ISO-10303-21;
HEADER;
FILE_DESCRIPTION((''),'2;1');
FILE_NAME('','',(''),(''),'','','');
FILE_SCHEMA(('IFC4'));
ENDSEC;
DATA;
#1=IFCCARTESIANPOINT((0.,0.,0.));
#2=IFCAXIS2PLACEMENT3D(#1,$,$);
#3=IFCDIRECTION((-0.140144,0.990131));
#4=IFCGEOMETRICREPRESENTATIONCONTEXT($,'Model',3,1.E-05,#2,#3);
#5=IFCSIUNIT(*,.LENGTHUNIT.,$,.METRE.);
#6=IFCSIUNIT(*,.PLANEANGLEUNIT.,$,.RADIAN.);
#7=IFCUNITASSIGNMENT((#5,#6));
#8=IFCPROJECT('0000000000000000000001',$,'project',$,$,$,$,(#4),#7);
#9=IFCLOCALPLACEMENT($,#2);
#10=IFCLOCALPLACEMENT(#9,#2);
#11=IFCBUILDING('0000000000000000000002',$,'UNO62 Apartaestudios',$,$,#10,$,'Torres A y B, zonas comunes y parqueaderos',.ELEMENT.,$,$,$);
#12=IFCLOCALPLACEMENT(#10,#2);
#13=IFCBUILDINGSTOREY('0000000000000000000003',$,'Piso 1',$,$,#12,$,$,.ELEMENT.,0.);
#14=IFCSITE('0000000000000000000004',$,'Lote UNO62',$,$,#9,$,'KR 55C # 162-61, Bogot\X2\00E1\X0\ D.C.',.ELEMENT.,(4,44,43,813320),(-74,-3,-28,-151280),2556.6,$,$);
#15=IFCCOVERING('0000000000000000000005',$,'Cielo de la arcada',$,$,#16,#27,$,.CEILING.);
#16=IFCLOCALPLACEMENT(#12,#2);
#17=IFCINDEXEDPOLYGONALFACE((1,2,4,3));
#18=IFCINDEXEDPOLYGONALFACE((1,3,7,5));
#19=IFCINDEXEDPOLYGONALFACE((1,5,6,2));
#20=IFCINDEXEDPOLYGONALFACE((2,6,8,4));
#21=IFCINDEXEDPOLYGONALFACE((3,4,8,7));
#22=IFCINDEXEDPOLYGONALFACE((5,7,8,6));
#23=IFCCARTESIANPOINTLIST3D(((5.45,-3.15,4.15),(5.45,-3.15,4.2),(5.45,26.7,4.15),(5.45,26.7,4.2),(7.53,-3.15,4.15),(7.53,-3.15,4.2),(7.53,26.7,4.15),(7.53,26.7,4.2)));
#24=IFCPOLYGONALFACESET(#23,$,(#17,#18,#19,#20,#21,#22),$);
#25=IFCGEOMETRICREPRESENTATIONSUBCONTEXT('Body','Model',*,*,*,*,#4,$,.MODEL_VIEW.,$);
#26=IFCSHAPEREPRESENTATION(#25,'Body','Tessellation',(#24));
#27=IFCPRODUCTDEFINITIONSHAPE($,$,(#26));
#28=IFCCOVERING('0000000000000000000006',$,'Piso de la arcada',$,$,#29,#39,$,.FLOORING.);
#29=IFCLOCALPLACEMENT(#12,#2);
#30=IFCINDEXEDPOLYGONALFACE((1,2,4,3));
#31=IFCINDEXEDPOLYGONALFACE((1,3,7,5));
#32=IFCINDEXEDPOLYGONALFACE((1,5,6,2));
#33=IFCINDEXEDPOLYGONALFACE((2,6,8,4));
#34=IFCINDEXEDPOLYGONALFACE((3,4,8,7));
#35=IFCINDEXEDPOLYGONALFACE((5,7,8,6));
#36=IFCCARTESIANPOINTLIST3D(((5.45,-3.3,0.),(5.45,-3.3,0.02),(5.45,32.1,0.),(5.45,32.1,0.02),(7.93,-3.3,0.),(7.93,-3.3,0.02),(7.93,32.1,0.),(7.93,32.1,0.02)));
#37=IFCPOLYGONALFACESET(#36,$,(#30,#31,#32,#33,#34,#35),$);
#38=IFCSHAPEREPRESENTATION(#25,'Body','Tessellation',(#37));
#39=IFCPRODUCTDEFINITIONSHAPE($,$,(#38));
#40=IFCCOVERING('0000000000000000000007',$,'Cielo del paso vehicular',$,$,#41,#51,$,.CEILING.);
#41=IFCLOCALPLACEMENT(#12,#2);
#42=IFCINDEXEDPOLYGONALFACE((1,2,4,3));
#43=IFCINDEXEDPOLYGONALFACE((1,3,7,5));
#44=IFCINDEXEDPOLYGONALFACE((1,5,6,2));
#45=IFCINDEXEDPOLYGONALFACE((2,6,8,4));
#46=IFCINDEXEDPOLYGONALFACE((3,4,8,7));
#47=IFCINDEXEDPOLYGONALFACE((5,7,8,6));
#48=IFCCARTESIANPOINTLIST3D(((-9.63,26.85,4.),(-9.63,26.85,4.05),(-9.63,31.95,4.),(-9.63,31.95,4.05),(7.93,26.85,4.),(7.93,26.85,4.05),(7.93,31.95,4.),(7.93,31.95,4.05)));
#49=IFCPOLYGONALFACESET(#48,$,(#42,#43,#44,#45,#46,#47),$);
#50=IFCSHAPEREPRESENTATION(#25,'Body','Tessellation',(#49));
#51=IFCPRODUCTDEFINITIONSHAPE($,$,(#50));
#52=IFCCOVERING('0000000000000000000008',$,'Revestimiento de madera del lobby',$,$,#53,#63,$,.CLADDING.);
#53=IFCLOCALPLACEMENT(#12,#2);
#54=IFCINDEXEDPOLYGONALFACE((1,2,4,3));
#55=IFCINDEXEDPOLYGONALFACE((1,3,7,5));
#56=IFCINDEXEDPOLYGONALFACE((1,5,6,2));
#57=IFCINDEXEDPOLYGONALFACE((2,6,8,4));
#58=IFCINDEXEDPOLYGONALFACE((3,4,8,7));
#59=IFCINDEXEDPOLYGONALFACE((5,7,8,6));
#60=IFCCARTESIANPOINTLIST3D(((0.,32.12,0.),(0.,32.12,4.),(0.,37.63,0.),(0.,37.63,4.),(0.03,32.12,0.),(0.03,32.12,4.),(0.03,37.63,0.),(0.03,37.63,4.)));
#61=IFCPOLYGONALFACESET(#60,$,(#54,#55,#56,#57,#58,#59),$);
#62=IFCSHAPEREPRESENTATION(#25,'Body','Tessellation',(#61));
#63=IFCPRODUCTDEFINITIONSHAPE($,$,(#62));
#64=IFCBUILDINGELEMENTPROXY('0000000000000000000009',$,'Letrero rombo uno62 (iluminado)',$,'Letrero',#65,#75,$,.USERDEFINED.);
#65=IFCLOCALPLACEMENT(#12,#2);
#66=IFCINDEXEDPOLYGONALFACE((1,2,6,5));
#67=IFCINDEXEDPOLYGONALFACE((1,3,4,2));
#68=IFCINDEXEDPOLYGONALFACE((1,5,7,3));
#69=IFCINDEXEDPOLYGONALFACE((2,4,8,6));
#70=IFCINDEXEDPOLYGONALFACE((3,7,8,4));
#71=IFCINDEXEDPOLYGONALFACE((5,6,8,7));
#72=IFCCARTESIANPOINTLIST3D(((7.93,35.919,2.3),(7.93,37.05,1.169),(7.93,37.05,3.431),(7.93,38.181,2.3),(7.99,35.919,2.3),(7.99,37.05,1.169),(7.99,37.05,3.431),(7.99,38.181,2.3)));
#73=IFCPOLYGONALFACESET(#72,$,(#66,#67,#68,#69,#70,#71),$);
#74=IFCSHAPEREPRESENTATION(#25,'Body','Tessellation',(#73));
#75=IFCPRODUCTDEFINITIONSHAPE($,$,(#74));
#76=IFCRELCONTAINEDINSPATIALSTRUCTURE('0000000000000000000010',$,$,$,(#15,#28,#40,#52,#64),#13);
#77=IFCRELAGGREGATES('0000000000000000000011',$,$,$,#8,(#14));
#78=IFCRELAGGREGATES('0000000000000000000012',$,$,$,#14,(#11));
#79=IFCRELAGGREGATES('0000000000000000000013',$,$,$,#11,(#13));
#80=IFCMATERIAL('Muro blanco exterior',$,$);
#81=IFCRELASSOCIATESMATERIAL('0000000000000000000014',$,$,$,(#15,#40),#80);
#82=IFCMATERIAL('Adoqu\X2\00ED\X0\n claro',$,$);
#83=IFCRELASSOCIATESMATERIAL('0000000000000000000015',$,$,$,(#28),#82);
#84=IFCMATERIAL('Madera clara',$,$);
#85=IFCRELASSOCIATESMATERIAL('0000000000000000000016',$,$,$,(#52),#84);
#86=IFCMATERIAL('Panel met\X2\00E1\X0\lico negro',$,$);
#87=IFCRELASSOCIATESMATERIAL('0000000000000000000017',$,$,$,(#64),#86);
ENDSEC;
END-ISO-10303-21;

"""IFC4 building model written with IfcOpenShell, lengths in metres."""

from ifc_helpers import new_model, si_unit, direction, frame, frame_2d, origin, place, context, subcontext, project, spatial, polyline, rectangle, outline, extrude, material, element, save


model = new_model("IFC4")

# Units and contexts
model_context = context("Model", 3, precision=1e-05, world=origin(), true_north=direction((-0.140144, 0.990131)))
body_context = subcontext(model_context, "Body", "Model", "MODEL_VIEW")
ifc_project = project(units=[si_unit("LENGTHUNIT", "METRE"), si_unit("PLANEANGLEUNIT", "RADIAN")], contexts=[model_context])

# Site, building, storey
site_placement = place(None, origin())
site = spatial("IfcSite", under=ifc_project, at=site_placement, Name="Lote UNO62", LongName="KR 55C # 162-61, Bogotá D.C.", CompositionType="ELEMENT", RefLatitude=(4, 44, 43, 813320), RefLongitude=(-74, -3, -28, -151280), RefElevation=2556.6)
building_placement = place(site_placement, origin())
building = spatial("IfcBuilding", under=site, at=building_placement, Name="UNO62 Apartaestudios", LongName="Torres A y B, zonas comunes y parqueaderos", CompositionType="ELEMENT")
storey_placement = place(building_placement, origin())
storey = spatial("IfcBuildingStorey", under=building, at=storey_placement, Name="Piso 1", CompositionType="ELEMENT", Elevation=0.0)

# Shared definitions
ifc_material_1 = material(Name="Panel metálico negro")

# Shared definitions
ifc_material_2 = material(Name="Muro blanco exterior")

# Coverings
covering_1_placement = place(storey_placement, origin())
element("IfcCovering", 1, at=covering_1_placement, inside=storey, material=ifc_material_2, Name="Cielo de la arcada", PredefinedType="CEILING", context=body_context, shape_type="SweptSolid", body=[
    extrude(rectangle(XDim=2.08, YDim=29.85, at=frame_2d((6.49, 11.775))), frame((0.0, 0.0, 4.15)), (0.0, 0.0, 1.0), 0.05),
])
ifc_material_3 = material(Name="Adoquín claro")
covering_2_placement = place(storey_placement, origin())
element("IfcCovering", 2, at=covering_2_placement, inside=storey, material=ifc_material_3, Name="Piso de la arcada", PredefinedType="FLOORING", context=body_context, shape_type="SweptSolid", body=[
    extrude(rectangle(XDim=2.48, YDim=35.4, at=frame_2d((6.69, 14.4))), origin(), (0.0, 0.0, 1.0), 0.02),
])
covering_3_placement = place(storey_placement, origin())
element("IfcCovering", 3, at=covering_3_placement, inside=storey, material=ifc_material_2, Name="Cielo del paso vehicular", PredefinedType="CEILING", context=body_context, shape_type="SweptSolid", body=[
    extrude(rectangle(XDim=17.56, YDim=5.1, at=frame_2d((-0.85, 29.4))), frame((0.0, 0.0, 4.0)), (0.0, 0.0, 1.0), 0.05),
])
ifc_material_4 = material(Name="Madera clara")
covering_4_placement = place(storey_placement, origin())
element("IfcCovering", 4, at=covering_4_placement, inside=storey, material=ifc_material_4, Name="Revestimiento de madera del lobby", PredefinedType="CLADDING", context=body_context, shape_type="SweptSolid", body=[
    extrude(rectangle(XDim=0.03, YDim=5.51, at=frame_2d((0.015, 34.875))), origin(), (0.0, 0.0, 1.0), 4.0),
])

# Building element proxy
proxy_placement = place(storey_placement, origin())
element("IfcBuildingElementProxy", 5, at=proxy_placement, inside=storey, material=ifc_material_1, Name="Letrero rombo uno62 (iluminado)", ObjectType="Letrero", PredefinedType="USERDEFINED", context=body_context, shape_type="SweptSolid", body=[
    extrude(outline(polyline([(1.131, 0.0), (0.0, 1.131), (-1.131, 0.0), (0.0, -1.131), (1.131, 0.0)])), frame((7.93, 37.05, 2.3), z_axis=(1.0, 0.0, 0.0), x_axis=(0.0, 1.0, 0.0)), (0.0, 0.0, 1.0), 0.06),
])

save(model, "model.ifc")
